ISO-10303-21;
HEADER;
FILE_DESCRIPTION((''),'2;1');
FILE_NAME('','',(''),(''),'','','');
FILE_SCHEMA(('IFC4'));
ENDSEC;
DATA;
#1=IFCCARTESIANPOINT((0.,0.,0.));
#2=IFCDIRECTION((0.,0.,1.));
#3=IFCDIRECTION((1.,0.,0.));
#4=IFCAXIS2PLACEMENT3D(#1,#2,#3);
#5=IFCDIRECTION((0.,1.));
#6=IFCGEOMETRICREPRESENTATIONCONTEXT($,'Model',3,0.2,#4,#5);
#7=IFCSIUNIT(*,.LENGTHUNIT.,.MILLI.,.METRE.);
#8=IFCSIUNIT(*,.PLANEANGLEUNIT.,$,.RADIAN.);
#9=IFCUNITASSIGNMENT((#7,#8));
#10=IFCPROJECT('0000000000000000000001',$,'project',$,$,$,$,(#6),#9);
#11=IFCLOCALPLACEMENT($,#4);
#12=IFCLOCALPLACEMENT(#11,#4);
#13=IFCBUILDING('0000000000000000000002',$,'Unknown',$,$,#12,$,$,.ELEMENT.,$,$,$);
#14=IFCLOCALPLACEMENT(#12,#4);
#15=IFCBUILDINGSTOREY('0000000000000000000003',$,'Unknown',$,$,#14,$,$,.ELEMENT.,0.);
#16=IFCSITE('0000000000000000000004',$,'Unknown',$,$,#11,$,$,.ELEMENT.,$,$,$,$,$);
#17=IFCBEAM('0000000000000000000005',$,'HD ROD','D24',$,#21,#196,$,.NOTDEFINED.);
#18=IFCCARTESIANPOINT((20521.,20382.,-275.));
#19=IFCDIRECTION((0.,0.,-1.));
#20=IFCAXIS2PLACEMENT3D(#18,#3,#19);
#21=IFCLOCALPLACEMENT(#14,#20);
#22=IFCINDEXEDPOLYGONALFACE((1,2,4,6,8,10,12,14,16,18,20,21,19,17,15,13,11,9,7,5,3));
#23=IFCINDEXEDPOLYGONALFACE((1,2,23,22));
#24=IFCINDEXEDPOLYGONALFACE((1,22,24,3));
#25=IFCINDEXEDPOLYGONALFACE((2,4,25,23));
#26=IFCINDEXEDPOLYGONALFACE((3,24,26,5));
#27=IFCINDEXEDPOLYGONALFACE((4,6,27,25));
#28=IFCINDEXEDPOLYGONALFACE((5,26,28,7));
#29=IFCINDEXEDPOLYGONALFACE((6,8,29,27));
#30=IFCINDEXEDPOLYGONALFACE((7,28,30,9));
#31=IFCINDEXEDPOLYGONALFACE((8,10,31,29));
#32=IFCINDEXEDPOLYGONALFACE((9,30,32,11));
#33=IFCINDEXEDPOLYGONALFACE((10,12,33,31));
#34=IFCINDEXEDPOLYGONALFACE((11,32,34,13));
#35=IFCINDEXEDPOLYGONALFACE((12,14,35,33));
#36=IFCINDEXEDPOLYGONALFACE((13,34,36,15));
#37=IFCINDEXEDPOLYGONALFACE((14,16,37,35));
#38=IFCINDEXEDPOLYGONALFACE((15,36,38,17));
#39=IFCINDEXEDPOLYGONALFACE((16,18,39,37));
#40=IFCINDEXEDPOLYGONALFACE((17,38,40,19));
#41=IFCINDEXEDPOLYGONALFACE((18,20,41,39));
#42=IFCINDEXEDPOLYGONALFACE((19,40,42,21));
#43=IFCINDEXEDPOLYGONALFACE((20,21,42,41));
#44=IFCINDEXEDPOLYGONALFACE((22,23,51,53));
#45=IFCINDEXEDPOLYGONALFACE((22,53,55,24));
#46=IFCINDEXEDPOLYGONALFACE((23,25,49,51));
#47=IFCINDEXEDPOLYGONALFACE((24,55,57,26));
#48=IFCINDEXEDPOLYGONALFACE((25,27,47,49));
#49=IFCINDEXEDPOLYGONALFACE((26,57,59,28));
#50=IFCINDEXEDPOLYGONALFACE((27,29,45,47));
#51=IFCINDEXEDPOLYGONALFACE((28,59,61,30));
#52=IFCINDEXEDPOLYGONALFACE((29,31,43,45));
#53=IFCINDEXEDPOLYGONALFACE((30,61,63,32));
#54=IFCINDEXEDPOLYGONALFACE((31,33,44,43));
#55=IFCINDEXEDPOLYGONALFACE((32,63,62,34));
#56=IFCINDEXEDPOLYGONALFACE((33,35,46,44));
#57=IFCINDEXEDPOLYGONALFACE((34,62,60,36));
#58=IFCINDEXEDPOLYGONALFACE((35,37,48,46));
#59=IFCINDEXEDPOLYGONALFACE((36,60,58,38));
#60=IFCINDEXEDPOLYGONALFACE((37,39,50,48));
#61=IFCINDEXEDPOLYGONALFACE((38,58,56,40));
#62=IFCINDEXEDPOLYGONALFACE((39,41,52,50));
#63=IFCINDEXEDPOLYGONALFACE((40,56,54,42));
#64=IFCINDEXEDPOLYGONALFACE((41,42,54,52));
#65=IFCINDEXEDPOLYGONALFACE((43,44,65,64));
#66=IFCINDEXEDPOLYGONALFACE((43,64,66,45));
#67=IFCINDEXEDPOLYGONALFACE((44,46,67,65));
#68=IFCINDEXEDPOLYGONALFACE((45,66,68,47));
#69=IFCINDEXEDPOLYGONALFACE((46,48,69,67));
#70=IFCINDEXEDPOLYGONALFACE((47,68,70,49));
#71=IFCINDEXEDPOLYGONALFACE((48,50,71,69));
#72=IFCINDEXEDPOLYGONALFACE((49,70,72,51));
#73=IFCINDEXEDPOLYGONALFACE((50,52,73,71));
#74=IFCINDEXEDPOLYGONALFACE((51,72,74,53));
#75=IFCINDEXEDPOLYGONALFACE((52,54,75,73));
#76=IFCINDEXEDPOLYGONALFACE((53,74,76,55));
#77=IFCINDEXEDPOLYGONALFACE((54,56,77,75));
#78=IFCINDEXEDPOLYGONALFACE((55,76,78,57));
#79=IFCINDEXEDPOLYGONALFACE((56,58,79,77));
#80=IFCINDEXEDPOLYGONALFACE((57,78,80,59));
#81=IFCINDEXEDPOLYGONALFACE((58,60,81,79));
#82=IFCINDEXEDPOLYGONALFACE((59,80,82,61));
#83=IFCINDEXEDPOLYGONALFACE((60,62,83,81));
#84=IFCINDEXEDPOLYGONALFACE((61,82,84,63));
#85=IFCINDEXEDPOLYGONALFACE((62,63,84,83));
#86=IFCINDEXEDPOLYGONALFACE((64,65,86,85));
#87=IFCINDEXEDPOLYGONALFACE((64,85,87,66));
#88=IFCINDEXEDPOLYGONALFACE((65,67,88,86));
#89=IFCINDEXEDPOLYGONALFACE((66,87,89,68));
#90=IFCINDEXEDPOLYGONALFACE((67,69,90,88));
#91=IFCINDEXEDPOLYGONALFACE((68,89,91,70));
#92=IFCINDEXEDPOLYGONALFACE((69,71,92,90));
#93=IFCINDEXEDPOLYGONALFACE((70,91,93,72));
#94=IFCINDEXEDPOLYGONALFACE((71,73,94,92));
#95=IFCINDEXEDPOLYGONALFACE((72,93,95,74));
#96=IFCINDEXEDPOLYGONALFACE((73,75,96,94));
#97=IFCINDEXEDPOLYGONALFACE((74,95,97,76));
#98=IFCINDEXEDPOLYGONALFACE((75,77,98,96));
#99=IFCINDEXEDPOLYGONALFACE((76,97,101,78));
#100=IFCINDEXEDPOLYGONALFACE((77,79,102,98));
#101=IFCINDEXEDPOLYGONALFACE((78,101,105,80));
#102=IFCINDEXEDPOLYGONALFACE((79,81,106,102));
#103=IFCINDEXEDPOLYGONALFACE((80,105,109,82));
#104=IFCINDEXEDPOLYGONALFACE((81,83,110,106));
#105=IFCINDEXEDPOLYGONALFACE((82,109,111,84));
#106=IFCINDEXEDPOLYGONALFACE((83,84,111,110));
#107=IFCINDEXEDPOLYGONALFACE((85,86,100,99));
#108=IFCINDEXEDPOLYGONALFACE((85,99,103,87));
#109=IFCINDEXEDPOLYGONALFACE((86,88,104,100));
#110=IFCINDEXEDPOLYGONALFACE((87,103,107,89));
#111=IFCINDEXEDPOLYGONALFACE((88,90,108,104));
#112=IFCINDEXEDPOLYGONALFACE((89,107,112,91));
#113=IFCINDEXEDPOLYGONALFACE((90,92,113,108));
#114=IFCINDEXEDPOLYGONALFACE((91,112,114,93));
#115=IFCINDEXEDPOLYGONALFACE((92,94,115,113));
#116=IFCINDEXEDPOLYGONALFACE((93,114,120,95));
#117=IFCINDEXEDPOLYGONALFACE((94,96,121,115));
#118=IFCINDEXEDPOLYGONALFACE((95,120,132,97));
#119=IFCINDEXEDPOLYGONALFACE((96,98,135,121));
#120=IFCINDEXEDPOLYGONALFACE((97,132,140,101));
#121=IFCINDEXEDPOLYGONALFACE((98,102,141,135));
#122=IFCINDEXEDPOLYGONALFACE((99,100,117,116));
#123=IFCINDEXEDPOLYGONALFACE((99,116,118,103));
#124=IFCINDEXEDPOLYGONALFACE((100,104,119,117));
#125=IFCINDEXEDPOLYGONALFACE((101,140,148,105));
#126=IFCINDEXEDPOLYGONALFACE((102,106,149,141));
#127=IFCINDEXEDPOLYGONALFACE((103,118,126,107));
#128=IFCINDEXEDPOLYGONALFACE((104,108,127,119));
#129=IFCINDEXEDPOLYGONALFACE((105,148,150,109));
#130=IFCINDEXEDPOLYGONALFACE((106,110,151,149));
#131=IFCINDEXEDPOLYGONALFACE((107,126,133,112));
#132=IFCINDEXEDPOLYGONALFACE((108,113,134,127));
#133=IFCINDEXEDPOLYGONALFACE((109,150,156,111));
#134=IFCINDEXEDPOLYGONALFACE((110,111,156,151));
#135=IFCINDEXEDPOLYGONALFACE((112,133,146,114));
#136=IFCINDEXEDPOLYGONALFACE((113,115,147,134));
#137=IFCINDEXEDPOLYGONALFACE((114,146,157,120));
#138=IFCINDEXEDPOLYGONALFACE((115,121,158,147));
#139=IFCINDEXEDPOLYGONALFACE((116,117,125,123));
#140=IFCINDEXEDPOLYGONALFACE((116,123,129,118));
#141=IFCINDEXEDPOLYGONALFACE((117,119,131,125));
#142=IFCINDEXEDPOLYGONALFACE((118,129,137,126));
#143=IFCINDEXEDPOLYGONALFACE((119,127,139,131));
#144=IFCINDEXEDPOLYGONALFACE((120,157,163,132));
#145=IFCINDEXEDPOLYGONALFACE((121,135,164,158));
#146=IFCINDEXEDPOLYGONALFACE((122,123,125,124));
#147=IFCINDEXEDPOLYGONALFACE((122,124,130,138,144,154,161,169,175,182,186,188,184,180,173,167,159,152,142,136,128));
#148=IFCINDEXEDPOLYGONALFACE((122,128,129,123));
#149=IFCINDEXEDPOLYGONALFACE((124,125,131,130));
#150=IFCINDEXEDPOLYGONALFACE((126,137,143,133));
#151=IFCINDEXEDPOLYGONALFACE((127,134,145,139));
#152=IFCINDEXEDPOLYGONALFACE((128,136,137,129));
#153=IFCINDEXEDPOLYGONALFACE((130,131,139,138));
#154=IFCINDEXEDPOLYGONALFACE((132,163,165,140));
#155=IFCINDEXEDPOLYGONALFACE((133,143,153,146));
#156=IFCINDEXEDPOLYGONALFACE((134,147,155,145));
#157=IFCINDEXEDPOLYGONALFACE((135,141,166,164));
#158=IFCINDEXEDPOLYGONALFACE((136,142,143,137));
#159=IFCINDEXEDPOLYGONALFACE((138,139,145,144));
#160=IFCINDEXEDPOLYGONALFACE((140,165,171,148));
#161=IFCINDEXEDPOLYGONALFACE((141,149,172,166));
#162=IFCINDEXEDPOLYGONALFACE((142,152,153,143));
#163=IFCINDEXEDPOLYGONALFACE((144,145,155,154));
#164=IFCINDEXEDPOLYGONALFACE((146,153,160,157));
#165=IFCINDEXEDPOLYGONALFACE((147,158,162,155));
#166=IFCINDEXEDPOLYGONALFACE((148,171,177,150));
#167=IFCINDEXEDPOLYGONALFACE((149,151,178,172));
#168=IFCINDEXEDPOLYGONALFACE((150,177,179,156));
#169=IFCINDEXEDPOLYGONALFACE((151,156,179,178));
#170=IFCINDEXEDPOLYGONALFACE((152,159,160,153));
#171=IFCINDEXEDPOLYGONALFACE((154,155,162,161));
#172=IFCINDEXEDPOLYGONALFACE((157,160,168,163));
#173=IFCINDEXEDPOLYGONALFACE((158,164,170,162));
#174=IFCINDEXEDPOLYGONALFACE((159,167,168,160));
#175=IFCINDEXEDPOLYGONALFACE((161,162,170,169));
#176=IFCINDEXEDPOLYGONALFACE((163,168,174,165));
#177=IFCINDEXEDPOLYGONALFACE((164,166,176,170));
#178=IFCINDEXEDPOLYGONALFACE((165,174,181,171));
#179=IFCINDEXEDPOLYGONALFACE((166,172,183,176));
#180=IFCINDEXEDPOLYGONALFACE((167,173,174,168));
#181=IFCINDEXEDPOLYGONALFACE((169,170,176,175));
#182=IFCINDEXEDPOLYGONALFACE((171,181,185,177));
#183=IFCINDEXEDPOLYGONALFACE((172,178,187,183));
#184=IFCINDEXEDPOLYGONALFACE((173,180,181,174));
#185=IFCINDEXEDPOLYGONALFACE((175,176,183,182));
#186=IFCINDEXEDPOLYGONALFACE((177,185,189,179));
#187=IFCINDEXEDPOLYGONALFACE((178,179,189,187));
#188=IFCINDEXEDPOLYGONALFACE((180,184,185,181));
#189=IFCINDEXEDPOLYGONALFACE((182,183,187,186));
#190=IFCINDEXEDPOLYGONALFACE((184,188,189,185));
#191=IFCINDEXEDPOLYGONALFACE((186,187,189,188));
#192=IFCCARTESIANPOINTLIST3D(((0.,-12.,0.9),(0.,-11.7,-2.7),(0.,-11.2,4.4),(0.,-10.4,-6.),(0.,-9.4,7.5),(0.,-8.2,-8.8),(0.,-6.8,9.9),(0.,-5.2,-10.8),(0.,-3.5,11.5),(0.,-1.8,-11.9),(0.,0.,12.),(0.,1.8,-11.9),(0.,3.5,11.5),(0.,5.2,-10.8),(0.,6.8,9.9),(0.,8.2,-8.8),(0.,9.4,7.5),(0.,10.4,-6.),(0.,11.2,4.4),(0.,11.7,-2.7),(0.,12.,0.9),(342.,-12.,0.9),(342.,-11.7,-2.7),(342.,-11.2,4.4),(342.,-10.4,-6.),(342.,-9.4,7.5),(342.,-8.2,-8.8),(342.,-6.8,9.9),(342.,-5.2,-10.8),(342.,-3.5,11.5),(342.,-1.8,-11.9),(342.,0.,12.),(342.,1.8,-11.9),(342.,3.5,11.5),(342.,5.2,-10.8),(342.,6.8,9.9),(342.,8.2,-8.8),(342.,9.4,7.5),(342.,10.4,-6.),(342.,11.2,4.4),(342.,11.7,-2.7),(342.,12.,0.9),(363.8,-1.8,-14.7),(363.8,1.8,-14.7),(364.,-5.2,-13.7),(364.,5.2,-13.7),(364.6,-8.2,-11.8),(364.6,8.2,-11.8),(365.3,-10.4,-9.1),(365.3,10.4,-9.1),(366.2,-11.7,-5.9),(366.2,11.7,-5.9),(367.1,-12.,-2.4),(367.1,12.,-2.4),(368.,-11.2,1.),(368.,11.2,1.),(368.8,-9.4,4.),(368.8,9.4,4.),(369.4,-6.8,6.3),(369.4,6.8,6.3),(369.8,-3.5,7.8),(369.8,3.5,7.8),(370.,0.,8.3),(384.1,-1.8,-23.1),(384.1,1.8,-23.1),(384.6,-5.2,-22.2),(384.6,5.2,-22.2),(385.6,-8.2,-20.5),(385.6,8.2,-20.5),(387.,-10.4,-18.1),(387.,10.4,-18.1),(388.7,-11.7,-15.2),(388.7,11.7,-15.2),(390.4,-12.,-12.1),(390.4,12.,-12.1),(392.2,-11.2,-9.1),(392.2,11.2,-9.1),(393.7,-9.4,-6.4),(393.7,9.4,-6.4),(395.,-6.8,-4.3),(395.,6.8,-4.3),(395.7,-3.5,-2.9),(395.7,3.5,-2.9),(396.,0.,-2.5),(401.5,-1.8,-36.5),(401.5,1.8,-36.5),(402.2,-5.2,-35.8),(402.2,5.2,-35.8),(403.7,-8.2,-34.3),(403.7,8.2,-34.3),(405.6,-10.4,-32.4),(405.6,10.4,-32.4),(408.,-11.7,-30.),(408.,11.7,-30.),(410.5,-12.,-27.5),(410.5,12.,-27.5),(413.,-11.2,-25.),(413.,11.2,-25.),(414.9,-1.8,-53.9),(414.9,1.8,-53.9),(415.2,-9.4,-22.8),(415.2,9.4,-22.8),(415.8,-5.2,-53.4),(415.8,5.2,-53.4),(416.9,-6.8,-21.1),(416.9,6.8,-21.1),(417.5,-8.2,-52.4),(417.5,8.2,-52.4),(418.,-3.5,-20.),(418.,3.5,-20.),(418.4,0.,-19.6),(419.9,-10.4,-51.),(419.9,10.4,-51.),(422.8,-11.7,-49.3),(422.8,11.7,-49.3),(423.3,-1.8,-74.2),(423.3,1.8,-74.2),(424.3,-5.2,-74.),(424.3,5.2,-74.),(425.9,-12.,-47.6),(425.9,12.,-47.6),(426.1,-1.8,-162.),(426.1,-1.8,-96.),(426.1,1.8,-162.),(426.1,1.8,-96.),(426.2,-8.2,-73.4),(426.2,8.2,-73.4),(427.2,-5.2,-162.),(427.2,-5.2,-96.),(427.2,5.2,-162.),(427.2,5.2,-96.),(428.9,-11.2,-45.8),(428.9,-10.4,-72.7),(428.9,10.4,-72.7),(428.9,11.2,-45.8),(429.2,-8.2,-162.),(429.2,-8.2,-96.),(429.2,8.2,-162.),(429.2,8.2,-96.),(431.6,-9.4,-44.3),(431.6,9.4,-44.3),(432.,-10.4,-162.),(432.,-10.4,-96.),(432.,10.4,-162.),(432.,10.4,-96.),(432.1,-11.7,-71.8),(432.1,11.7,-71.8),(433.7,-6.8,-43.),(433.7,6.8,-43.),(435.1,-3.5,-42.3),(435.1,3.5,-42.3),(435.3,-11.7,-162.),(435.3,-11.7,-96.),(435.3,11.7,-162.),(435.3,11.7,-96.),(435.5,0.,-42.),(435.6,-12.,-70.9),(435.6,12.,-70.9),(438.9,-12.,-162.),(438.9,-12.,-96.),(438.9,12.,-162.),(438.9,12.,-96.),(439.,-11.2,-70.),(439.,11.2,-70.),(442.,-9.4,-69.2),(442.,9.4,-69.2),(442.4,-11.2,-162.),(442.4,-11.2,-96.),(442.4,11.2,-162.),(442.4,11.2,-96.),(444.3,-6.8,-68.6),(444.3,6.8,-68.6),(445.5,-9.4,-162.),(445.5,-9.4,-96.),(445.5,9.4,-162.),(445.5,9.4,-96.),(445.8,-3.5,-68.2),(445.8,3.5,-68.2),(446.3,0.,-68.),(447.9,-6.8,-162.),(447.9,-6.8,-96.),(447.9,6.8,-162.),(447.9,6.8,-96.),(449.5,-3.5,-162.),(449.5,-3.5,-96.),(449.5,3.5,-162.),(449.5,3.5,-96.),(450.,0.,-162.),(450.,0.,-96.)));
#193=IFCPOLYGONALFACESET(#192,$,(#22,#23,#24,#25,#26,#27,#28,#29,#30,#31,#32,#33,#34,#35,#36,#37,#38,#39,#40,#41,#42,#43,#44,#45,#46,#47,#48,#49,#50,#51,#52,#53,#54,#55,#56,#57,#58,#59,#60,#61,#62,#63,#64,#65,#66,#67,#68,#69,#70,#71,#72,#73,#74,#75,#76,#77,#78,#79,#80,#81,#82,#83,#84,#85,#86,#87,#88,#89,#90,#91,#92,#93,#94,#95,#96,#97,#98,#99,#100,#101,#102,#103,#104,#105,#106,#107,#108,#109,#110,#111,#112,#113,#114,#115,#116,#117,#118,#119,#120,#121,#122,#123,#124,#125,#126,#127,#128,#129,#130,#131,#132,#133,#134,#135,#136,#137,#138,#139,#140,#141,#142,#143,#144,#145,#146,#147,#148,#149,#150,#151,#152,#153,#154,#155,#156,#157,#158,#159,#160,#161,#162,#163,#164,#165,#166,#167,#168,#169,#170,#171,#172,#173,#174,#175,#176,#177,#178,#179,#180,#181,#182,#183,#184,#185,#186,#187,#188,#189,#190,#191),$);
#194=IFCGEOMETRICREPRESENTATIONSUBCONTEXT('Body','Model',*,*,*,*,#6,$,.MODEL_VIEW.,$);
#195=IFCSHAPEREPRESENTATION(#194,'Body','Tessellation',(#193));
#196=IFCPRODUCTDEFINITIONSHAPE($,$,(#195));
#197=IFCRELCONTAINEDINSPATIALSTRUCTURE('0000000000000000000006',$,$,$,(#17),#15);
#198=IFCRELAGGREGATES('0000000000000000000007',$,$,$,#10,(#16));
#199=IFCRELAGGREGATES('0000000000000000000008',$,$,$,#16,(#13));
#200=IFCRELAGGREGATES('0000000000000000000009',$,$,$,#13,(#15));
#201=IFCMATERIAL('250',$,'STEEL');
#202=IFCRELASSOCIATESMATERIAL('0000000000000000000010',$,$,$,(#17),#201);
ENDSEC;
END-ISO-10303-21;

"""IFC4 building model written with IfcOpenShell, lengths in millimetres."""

from ifc_helpers import new_model, entity, si_unit, direction, frame, origin_with_axes, place, context, subcontext, project, spatial, material, element, save


model = new_model("IFC4")

# Units and contexts
model_context = context("Model", 3, precision=0.2, world=origin_with_axes(), true_north=direction((0.0, 1.0)))
body_context = subcontext(model_context, "Body", "Model", "MODEL_VIEW")
ifc_project = project(units=[si_unit("LENGTHUNIT", "METRE", prefix="MILLI"), si_unit("PLANEANGLEUNIT", "RADIAN")], contexts=[model_context])

# Site, building, storey
site_placement = place(None, origin_with_axes())
site = spatial("IfcSite", under=ifc_project, at=site_placement, Name="Unknown", CompositionType="ELEMENT")
building_placement = place(site_placement, origin_with_axes())
building = spatial("IfcBuilding", under=site, at=building_placement, Name="Unknown", CompositionType="ELEMENT")
storey_placement = place(building_placement, origin_with_axes())
storey = spatial("IfcBuildingStorey", under=building, at=storey_placement, Name="Unknown", CompositionType="ELEMENT", Elevation=0.0)

# Shared definitions
ifc_material_1 = material(Name="250", Category="STEEL")

# Beam
beam_1_placement = place(storey_placement, frame((20521.0, 20382.0, -275.0), z_axis=(1.0, 0.0, 0.0), x_axis=(0.0, 0.0, -1.0)))
element("IfcBeam", 1, at=beam_1_placement, inside=storey, material=ifc_material_1, Name="HD ROD", Description="D24", PredefinedType="NOTDEFINED", context=body_context, shape_type="SolidModel", body=[
    entity("IfcSweptDiskSolid", entity("IfcIndexedPolyCurve", entity("IfcCartesianPointList3D", [[0.0, 0.0, 0.0], [342.0, 0.0, 0.0], [409.9, 0.0, -28.1], [438.0, 0.0, -96.0], [438.0, 0.0, -162.0]]), [entity("IfcLineIndex", [1, 2]), entity("IfcArcIndex", [2, 3, 4]), entity("IfcLineIndex", [4, 5])]), 12.0),
])

save(model, "model.ifc")
